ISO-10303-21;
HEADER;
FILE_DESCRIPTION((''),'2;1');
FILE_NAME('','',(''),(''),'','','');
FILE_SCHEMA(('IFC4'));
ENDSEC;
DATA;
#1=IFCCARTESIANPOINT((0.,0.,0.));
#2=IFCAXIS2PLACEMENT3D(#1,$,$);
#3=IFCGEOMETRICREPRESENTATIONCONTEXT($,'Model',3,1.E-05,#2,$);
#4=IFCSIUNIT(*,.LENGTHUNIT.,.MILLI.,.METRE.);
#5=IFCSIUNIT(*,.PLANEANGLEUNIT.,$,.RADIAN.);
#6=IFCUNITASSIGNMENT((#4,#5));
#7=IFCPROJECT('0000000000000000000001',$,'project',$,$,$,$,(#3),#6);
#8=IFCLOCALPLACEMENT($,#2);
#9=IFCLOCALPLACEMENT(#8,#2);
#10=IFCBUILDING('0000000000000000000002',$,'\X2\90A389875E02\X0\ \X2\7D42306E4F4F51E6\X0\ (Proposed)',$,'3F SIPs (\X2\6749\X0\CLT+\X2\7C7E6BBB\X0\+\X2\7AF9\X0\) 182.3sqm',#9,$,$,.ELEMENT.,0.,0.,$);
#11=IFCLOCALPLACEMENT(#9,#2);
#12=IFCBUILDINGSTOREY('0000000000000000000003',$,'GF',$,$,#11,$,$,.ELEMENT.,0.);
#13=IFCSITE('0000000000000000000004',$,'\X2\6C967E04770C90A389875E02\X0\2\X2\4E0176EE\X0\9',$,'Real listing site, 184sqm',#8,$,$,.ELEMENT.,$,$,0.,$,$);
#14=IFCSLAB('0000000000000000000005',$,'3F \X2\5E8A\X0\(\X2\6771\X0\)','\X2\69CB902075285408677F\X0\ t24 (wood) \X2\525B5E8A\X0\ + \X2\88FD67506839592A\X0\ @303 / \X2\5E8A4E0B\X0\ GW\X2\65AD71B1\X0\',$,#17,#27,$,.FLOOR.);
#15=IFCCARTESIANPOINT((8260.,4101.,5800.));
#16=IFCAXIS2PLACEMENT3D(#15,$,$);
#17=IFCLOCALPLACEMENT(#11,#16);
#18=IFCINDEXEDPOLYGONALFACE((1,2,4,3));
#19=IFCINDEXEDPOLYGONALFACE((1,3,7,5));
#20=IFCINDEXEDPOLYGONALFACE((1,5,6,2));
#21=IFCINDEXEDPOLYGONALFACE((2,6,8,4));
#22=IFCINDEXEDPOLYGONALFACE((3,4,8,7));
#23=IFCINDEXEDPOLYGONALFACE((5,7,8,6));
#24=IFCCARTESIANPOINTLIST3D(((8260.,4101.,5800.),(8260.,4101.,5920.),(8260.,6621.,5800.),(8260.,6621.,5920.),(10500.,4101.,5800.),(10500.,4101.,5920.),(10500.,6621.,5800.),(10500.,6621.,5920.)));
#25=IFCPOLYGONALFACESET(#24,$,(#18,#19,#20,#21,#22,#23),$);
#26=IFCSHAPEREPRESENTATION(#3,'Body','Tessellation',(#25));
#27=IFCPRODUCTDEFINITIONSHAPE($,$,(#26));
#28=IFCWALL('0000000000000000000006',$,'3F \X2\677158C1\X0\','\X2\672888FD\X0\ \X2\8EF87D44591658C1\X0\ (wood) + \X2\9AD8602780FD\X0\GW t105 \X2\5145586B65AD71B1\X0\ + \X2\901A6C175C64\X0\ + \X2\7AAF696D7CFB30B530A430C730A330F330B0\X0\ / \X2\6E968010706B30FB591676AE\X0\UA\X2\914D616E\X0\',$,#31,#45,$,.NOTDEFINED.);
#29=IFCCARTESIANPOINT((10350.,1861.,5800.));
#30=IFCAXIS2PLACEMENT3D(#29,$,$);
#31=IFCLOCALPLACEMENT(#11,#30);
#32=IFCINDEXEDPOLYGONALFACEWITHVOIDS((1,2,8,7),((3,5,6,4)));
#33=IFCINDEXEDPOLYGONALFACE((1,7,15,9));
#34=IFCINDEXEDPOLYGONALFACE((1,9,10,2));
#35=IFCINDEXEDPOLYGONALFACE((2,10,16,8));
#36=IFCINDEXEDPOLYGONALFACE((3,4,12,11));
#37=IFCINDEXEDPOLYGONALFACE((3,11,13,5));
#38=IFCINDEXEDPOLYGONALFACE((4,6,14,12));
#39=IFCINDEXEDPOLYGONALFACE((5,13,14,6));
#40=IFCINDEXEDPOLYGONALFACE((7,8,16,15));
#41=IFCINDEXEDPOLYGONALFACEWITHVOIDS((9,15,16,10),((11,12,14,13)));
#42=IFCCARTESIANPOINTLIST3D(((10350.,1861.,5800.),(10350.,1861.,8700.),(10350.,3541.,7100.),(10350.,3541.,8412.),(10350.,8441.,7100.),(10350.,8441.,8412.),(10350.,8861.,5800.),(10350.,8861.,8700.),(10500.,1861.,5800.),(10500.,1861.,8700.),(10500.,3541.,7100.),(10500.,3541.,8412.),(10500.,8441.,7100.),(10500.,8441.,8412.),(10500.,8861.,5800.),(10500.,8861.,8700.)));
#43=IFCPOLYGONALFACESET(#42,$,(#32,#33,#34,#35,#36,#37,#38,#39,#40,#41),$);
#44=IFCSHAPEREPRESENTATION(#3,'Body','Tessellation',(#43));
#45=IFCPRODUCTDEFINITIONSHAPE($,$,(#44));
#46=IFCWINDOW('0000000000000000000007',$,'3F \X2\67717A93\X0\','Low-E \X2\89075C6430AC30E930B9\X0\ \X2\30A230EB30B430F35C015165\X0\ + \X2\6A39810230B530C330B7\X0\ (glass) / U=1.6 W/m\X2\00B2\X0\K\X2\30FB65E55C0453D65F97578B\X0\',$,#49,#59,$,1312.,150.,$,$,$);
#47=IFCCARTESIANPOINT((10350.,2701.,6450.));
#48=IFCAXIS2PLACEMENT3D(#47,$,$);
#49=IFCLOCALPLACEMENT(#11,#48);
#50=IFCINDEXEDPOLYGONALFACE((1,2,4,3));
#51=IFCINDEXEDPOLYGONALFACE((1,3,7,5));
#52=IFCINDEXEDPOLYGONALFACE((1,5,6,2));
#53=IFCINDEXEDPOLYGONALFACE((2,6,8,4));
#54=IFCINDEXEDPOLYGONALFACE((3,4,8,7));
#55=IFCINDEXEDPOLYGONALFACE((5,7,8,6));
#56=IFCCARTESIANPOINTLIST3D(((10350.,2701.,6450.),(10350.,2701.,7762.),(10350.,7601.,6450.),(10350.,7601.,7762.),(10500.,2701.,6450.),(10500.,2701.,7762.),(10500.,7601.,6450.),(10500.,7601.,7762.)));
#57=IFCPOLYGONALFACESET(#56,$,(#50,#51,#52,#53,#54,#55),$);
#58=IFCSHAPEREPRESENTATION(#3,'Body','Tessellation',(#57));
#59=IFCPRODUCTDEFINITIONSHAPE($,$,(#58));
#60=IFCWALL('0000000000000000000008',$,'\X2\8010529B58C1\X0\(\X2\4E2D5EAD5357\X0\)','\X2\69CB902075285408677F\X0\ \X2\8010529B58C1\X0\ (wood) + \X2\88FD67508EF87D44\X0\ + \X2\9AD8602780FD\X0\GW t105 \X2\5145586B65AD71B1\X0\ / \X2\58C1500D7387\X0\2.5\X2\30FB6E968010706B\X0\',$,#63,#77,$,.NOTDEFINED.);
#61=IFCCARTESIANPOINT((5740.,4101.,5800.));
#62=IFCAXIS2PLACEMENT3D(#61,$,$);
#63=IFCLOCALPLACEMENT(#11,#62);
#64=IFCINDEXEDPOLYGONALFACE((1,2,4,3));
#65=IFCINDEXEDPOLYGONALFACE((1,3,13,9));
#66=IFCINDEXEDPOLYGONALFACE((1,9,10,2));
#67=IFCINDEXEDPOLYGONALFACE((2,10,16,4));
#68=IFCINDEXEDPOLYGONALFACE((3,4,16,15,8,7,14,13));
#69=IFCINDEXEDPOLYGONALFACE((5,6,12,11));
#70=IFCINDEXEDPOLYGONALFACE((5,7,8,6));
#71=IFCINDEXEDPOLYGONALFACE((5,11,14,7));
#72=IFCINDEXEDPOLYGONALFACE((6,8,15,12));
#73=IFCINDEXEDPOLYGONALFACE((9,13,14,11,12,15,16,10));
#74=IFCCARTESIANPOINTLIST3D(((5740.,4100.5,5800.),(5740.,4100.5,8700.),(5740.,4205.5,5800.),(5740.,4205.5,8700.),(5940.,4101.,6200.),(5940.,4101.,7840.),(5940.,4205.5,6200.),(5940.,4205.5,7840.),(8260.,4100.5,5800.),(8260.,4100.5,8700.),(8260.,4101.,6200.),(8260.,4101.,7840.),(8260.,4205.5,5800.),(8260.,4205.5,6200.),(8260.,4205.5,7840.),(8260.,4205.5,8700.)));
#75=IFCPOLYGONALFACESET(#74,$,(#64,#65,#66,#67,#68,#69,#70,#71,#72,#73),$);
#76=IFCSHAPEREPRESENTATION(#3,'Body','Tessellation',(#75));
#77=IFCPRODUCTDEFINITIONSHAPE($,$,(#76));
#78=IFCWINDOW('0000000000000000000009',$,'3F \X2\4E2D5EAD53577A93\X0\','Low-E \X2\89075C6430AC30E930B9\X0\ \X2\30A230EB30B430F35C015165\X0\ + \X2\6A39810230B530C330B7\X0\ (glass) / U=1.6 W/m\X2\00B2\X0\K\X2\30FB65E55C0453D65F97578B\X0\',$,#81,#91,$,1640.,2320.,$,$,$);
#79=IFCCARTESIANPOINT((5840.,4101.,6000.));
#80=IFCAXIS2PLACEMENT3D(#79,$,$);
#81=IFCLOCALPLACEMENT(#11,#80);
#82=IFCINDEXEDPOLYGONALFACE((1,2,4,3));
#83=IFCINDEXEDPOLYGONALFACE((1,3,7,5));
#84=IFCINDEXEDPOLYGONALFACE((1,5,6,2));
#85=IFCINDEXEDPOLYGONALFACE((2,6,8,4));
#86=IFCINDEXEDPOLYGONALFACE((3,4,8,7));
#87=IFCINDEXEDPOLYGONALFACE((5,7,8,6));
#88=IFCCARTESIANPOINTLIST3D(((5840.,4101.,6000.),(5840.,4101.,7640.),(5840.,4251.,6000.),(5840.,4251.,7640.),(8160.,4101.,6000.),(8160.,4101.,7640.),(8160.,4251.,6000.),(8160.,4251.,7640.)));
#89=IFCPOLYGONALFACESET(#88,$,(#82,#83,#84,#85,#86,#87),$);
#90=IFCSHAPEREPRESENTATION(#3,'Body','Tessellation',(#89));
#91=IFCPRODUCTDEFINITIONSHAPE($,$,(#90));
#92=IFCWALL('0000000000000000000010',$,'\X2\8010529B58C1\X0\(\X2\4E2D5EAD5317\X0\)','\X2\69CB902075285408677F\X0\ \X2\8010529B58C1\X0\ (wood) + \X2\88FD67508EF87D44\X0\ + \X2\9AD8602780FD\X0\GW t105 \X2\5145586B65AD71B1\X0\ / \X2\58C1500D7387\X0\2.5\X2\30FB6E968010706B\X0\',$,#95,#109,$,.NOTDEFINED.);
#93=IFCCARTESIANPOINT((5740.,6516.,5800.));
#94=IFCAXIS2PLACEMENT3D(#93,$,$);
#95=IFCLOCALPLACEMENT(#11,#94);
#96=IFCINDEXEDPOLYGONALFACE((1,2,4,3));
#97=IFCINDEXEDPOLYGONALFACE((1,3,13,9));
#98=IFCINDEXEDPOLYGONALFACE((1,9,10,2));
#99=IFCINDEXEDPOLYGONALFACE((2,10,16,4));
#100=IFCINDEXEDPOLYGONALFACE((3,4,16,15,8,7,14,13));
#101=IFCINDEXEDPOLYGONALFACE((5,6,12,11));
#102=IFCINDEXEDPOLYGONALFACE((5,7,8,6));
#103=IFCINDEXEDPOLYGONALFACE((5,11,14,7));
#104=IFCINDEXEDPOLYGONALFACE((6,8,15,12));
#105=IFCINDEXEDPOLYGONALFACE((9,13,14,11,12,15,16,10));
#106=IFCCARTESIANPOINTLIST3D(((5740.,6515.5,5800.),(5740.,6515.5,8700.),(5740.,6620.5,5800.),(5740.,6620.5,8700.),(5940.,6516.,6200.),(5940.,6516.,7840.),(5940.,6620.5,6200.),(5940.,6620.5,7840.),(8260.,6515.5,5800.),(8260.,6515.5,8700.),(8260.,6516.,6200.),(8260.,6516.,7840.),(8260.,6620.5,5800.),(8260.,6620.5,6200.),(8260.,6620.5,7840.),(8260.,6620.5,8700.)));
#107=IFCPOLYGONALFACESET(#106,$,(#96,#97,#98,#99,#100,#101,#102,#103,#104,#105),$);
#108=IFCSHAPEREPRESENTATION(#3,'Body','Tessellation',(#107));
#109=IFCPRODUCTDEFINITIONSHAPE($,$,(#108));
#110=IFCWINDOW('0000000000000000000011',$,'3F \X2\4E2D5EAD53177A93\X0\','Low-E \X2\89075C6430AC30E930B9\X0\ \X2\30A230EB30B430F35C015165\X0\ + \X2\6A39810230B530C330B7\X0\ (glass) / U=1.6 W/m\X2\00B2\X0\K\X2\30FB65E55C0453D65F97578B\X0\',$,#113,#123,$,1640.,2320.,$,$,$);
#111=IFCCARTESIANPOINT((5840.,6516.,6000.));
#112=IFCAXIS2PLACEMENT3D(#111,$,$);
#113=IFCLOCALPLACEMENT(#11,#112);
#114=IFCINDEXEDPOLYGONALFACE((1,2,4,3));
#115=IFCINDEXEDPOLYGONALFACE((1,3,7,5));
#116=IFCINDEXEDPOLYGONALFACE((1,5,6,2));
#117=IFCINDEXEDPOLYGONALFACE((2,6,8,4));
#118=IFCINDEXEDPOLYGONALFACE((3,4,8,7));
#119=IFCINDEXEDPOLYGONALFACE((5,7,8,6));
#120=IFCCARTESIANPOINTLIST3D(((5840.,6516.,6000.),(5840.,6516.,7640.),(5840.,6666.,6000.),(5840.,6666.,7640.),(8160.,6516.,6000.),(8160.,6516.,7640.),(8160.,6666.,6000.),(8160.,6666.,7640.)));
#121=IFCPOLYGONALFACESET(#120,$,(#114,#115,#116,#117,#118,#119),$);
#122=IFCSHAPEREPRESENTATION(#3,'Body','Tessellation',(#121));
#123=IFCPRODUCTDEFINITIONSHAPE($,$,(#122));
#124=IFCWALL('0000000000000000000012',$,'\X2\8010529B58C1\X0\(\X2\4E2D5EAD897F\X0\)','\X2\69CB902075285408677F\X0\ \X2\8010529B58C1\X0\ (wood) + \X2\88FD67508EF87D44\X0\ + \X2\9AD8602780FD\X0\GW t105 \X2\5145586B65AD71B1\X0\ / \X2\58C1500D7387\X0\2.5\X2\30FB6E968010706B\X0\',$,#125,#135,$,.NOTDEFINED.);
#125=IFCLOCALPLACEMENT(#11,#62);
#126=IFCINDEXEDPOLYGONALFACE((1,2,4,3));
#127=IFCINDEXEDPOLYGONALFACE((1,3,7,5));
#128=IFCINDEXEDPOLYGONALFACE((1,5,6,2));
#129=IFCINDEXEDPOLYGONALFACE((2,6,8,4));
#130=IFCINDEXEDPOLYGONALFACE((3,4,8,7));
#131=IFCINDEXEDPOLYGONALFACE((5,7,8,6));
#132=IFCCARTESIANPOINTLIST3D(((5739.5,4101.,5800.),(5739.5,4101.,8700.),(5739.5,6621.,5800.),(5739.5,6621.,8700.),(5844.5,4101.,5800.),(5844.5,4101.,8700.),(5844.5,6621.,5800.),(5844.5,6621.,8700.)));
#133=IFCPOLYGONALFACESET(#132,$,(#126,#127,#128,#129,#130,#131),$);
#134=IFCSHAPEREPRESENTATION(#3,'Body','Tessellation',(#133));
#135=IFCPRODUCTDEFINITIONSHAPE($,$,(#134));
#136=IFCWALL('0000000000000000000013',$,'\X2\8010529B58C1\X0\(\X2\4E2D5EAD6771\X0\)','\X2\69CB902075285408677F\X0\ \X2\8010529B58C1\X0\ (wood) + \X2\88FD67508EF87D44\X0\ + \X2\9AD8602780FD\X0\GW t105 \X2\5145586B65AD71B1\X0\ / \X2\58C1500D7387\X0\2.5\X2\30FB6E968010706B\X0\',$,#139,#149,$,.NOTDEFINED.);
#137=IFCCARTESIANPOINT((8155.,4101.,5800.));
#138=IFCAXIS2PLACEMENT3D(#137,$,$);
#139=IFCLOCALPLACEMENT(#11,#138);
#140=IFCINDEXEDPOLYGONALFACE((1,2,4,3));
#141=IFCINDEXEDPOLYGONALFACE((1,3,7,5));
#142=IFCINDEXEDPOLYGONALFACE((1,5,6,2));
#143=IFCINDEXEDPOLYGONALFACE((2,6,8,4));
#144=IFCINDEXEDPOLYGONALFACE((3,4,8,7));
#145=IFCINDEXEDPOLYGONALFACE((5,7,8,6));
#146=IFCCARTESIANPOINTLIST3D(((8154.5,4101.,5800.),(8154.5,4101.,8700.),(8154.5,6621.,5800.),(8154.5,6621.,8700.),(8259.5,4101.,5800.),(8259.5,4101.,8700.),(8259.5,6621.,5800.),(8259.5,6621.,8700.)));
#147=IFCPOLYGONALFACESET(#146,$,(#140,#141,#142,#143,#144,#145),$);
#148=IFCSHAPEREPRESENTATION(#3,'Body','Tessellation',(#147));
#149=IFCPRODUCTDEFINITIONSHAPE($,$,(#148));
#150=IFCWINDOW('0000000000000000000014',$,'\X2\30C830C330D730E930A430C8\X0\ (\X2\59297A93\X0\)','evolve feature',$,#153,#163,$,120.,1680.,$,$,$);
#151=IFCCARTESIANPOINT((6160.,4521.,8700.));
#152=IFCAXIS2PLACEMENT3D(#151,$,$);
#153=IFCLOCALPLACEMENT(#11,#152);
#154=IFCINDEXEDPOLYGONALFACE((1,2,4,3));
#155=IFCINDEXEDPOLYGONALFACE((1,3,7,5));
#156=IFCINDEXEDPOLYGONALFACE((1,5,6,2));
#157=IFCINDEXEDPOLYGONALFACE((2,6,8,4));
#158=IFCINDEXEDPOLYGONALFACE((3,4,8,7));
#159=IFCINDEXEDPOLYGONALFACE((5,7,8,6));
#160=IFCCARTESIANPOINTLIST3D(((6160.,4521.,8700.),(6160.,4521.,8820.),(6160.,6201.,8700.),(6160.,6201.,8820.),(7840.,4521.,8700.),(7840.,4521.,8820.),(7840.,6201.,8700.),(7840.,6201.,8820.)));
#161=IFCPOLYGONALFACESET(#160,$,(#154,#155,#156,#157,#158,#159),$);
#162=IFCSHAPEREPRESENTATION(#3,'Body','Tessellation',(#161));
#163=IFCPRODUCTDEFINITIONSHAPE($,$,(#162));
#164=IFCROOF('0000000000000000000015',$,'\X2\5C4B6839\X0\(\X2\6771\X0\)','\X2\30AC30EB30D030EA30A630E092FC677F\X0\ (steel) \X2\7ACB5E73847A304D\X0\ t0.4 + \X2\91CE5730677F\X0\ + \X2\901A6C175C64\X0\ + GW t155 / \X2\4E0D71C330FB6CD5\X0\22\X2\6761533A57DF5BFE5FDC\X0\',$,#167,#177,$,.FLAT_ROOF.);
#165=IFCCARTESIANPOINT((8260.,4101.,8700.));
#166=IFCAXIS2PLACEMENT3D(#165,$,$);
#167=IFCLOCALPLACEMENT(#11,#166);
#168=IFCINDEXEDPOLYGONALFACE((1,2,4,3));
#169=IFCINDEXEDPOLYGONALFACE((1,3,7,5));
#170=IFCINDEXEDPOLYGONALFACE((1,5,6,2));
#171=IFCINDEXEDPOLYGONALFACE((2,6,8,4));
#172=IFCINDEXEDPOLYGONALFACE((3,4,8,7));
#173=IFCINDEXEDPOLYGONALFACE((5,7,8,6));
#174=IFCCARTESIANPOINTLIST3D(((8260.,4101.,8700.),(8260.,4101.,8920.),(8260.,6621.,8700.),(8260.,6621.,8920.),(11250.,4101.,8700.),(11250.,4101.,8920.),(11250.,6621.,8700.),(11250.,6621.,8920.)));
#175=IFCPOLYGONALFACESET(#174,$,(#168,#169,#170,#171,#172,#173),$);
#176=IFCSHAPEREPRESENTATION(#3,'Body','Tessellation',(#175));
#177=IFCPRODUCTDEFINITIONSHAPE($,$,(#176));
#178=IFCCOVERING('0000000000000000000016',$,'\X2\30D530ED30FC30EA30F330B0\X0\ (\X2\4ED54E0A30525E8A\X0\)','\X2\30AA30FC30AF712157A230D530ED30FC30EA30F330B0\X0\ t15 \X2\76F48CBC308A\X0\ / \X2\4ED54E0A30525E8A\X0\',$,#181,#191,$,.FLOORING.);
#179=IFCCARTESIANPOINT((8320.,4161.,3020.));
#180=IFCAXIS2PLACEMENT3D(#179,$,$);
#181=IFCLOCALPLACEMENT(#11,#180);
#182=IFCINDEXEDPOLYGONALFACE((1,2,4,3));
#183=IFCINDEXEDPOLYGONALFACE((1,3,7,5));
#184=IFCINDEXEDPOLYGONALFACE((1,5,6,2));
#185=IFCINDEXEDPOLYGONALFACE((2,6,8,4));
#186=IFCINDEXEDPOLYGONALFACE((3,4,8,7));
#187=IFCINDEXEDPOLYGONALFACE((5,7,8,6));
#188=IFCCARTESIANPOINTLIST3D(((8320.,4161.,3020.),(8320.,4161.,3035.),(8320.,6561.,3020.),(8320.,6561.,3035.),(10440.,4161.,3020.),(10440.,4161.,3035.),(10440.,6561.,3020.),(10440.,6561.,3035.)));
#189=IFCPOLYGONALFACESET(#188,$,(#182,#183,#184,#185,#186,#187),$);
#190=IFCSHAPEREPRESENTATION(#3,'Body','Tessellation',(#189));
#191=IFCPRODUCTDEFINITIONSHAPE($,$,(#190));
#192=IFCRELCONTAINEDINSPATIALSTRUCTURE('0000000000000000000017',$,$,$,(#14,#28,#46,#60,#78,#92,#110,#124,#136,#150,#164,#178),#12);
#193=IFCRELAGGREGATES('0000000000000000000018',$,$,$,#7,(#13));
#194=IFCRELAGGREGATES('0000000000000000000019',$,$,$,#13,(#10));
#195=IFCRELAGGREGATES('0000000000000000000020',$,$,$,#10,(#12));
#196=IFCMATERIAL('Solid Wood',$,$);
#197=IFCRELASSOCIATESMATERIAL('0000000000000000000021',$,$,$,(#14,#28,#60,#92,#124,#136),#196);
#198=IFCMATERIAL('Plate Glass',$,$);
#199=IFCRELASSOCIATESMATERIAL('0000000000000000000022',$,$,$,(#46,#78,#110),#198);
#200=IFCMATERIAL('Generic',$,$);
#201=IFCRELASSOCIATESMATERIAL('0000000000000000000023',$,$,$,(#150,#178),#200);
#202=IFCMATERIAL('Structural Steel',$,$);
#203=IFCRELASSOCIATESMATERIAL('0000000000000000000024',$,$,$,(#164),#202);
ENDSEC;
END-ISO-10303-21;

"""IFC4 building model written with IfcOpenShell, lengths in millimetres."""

from ifc_helpers import new_model, si_unit, frame, frame_2d, origin, place, context, project, spatial, rectangle, extrude, material, element, fill, save


model = new_model("IFC4")

# Units and contexts
model_context = context("Model", 3, precision=1e-05, world=origin())
ifc_project = project(units=[si_unit("LENGTHUNIT", "METRE", prefix="MILLI"), si_unit("PLANEANGLEUNIT", "RADIAN")], contexts=[model_context])

# Site, building, storey
site_placement = place(None, origin())
site = spatial("IfcSite", under=ifc_project, at=site_placement, Name="沖縄県那覇市2丁目9", ObjectType="Real listing site, 184sqm", CompositionType="ELEMENT", RefElevation=0.0)
building_placement = place(site_placement, origin())
building = spatial("IfcBuilding", under=site, at=building_placement, Name="那覇市 終の住処 (Proposed)", ObjectType="3F SIPs (杉CLT+籾殻+竹) 182.3sqm", CompositionType="ELEMENT", ElevationOfRefHeight=0.0, ElevationOfTerrain=0.0)
storey_placement = place(building_placement, origin())
storey = spatial("IfcBuildingStorey", under=building, at=storey_placement, Name="GF", CompositionType="ELEMENT", Elevation=0.0)

# Slab
ifc_material_1 = material(Name="Solid Wood")
slab_placement = place(storey_placement, frame((8260.0, 4101.0, 5800.0)))
element("IfcSlab", 1, at=slab_placement, inside=storey, material=ifc_material_1, Name="3F 床(東)", Description="構造用合板 t24 (wood) 剛床 + 製材根太 @303 / 床下 GW断熱", PredefinedType="FLOOR", context=model_context, shape_type="SweptSolid", body=[
    extrude(rectangle(XDim=2240.0, YDim=2520.0, at=frame_2d((1120.0, 1260.0))), frame((8260.0, 4101.0, 5800.0)), (0.0, 0.0, 1.0), 120.0),
])

# Walls, openings, windows
wall_1_placement = place(storey_placement, frame((10350.0, 1861.0, 5800.0)))
wall_1 = element("IfcWall", 2, at=wall_1_placement, inside=storey, material=ifc_material_1, Name="3F 東壁", Description="木製 軸組外壁 (wood) + 高性能GW t105 充填断熱 + 通気層 + 窯業系サイディング / 準耐火・外皮UA配慮", PredefinedType="NOTDEFINED", context=model_context, shape_type="SweptSolid", body=[
    extrude(rectangle(XDim=150.0, YDim=7000.0, at=frame_2d((75.0, 3500.0))), frame((10350.0, 1861.0, 5800.0)), (0.0, 0.0, 1.0), 2900.0),
])
opening_1_placement = place(storey_placement, frame((10350.0, 2701.0, 6450.0)))
opening_1 = element("IfcOpeningElement", 3, at=opening_1_placement, cuts=wall_1, PredefinedType="NOTDEFINED", context=model_context, shape_type="SweptSolid", body=[
    extrude(rectangle(XDim=150.0, YDim=4900.0, at=frame_2d((75.0, 2450.0))), frame((10350.0, 2701.0, 6450.0)), (0.0, 0.0, 1.0), 1312.0),
])
ifc_material_2 = material(Name="Plate Glass")
window_1_placement = place(storey_placement, frame((10350.0, 2701.0, 6450.0)))
window_1 = element("IfcWindow", 4, at=window_1_placement, inside=storey, material=ifc_material_2, Name="3F 東窓", Description="Low-E 複層ガラス アルゴン封入 + 樹脂サッシ (glass) / U=1.6 W/m²K・日射取得型", OverallHeight=1312.0, OverallWidth=150.0, context=model_context, shape_type="SweptSolid", body=[
    extrude(rectangle(XDim=150.0, YDim=4900.0, at=frame_2d((75.0, 2450.0))), frame((10350.0, 2701.0, 6450.0)), (0.0, 0.0, 1.0), 1312.0),
])
fill(opening_1, window_1)
wall_2_placement = place(storey_placement, frame((5740.0, 4101.0, 5800.0)))
wall_2 = element("IfcWall", 5, at=wall_2_placement, inside=storey, material=ifc_material_1, Name="耐力壁(中庭南)", Description="構造用合板 耐力壁 (wood) + 製材軸組 + 高性能GW t105 充填断熱 / 壁倍率2.5・準耐火", PredefinedType="NOTDEFINED", context=model_context, shape_type="SweptSolid", body=[
    extrude(rectangle(XDim=2520.0, YDim=105.0, at=frame_2d((1260.0, 52.0))), frame((5740.0, 4101.0, 5800.0)), (0.0, 0.0, 1.0), 2900.0),
])
opening_2_placement = place(storey_placement, frame((5840.0, 4101.0, 6000.0)))
opening_2 = element("IfcOpeningElement", 6, at=opening_2_placement, cuts=wall_2, PredefinedType="NOTDEFINED", context=model_context, shape_type="SweptSolid", body=[
    extrude(rectangle(XDim=2320.0, YDim=150.0, at=frame_2d((1160.0, 75.0))), frame((5840.0, 4101.0, 6000.0)), (0.0, 0.0, 1.0), 1640.0),
])
window_2_placement = place(storey_placement, frame((5840.0, 4101.0, 6000.0)))
window_2 = element("IfcWindow", 7, at=window_2_placement, inside=storey, material=ifc_material_2, Name="3F 中庭南窓", Description="Low-E 複層ガラス アルゴン封入 + 樹脂サッシ (glass) / U=1.6 W/m²K・日射取得型", OverallHeight=1640.0, OverallWidth=2320.0, context=model_context, shape_type="SweptSolid", body=[
    extrude(rectangle(XDim=2320.0, YDim=150.0, at=frame_2d((1160.0, 75.0))), frame((5840.0, 4101.0, 6000.0)), (0.0, 0.0, 1.0), 1640.0),
])
fill(opening_2, window_2)
wall_3_placement = place(storey_placement, frame((5740.0, 6516.0, 5800.0)))
wall_3 = element("IfcWall", 8, at=wall_3_placement, inside=storey, material=ifc_material_1, Name="耐力壁(中庭北)", Description="構造用合板 耐力壁 (wood) + 製材軸組 + 高性能GW t105 充填断熱 / 壁倍率2.5・準耐火", PredefinedType="NOTDEFINED", context=model_context, shape_type="SweptSolid", body=[
    extrude(rectangle(XDim=2520.0, YDim=105.0, at=frame_2d((1260.0, 52.0))), frame((5740.0, 6516.0, 5800.0)), (0.0, 0.0, 1.0), 2900.0),
])
opening_3_placement = place(storey_placement, frame((5840.0, 6516.0, 6000.0)))
opening_3 = element("IfcOpeningElement", 9, at=opening_3_placement, cuts=wall_3, PredefinedType="NOTDEFINED", context=model_context, shape_type="SweptSolid", body=[
    extrude(rectangle(XDim=2320.0, YDim=150.0, at=frame_2d((1160.0, 75.0))), frame((5840.0, 6516.0, 6000.0)), (0.0, 0.0, 1.0), 1640.0),
])
window_3_placement = place(storey_placement, frame((5840.0, 6516.0, 6000.0)))
window_3 = element("IfcWindow", 10, at=window_3_placement, inside=storey, material=ifc_material_2, Name="3F 中庭北窓", Description="Low-E 複層ガラス アルゴン封入 + 樹脂サッシ (glass) / U=1.6 W/m²K・日射取得型", OverallHeight=1640.0, OverallWidth=2320.0, context=model_context, shape_type="SweptSolid", body=[
    extrude(rectangle(XDim=2320.0, YDim=150.0, at=frame_2d((1160.0, 75.0))), frame((5840.0, 6516.0, 6000.0)), (0.0, 0.0, 1.0), 1640.0),
])
fill(opening_3, window_3)

# Walls
wall_4_placement = place(storey_placement, frame((5740.0, 4101.0, 5800.0)))
element("IfcWall", 11, at=wall_4_placement, inside=storey, material=ifc_material_1, Name="耐力壁(中庭西)", Description="構造用合板 耐力壁 (wood) + 製材軸組 + 高性能GW t105 充填断熱 / 壁倍率2.5・準耐火", PredefinedType="NOTDEFINED", context=model_context, shape_type="SweptSolid", body=[
    extrude(rectangle(XDim=105.0, YDim=2520.0, at=frame_2d((52.0, 1260.0))), frame((5740.0, 4101.0, 5800.0)), (0.0, 0.0, 1.0), 2900.0),
])
wall_5_placement = place(storey_placement, frame((8155.0, 4101.0, 5800.0)))
element("IfcWall", 12, at=wall_5_placement, inside=storey, material=ifc_material_1, Name="耐力壁(中庭東)", Description="構造用合板 耐力壁 (wood) + 製材軸組 + 高性能GW t105 充填断熱 / 壁倍率2.5・準耐火", PredefinedType="NOTDEFINED", context=model_context, shape_type="SweptSolid", body=[
    extrude(rectangle(XDim=105.0, YDim=2520.0, at=frame_2d((52.0, 1260.0))), frame((8155.0, 4101.0, 5800.0)), (0.0, 0.0, 1.0), 2900.0),
])

# Window
ifc_material_3 = material(Name="Generic")
window_4_placement = place(storey_placement, frame((6160.0, 4521.0, 8700.0)))
element("IfcWindow", 13, at=window_4_placement, inside=storey, material=ifc_material_3, Name="トップライト (天窓)", Description="evolve feature", OverallHeight=120.0, OverallWidth=1680.0, context=model_context, shape_type="SweptSolid", body=[
    extrude(rectangle(XDim=1680.0, YDim=1680.0, at=frame_2d((840.0, 840.0))), frame((6160.0, 4521.0, 8700.0)), (0.0, 0.0, 1.0), 120.0),
])

# Roof
ifc_material_4 = material(Name="Structural Steel")
for number, where, name in (
    (14, (8260.0, 4101.0, 8700.0), "屋根(東)"),
):
    element("IfcRoof", number, at=place(storey_placement, frame(where)), inside=storey, material=ifc_material_4, Name=name, Description="ガルバリウム鋼板 (steel) 立平葺き t0.4 + 野地板 + 通気層 + GW t155 / 不燃・法22条区域対応", PredefinedType="FLAT_ROOF", context=model_context, shape_type="SweptSolid", body=[
        extrude(rectangle(XDim=2990.0, YDim=2520.0, at=frame_2d((1495.0, 1260.0))), frame((8260.0, 4101.0, 8700.0)), (0.0, 0.0, 1.0), 220.0),
    ])

# Covering
covering_1_placement = place(storey_placement, frame((8320.0, 4161.0, 3020.0)))
element("IfcCovering", 15, at=covering_1_placement, inside=storey, material=ifc_material_3, Name="フローリング (仕上げ床)", Description="オーク無垢フローリング t15 直貼り / 仕上げ床", PredefinedType="FLOORING", context=model_context, shape_type="SweptSolid", body=[
    extrude(rectangle(XDim=2120.0, YDim=2400.0, at=frame_2d((1060.0, 1200.0))), frame((8320.0, 4161.0, 3020.0)), (0.0, 0.0, 1.0), 15.0),
])

save(model, "model.ifc")
